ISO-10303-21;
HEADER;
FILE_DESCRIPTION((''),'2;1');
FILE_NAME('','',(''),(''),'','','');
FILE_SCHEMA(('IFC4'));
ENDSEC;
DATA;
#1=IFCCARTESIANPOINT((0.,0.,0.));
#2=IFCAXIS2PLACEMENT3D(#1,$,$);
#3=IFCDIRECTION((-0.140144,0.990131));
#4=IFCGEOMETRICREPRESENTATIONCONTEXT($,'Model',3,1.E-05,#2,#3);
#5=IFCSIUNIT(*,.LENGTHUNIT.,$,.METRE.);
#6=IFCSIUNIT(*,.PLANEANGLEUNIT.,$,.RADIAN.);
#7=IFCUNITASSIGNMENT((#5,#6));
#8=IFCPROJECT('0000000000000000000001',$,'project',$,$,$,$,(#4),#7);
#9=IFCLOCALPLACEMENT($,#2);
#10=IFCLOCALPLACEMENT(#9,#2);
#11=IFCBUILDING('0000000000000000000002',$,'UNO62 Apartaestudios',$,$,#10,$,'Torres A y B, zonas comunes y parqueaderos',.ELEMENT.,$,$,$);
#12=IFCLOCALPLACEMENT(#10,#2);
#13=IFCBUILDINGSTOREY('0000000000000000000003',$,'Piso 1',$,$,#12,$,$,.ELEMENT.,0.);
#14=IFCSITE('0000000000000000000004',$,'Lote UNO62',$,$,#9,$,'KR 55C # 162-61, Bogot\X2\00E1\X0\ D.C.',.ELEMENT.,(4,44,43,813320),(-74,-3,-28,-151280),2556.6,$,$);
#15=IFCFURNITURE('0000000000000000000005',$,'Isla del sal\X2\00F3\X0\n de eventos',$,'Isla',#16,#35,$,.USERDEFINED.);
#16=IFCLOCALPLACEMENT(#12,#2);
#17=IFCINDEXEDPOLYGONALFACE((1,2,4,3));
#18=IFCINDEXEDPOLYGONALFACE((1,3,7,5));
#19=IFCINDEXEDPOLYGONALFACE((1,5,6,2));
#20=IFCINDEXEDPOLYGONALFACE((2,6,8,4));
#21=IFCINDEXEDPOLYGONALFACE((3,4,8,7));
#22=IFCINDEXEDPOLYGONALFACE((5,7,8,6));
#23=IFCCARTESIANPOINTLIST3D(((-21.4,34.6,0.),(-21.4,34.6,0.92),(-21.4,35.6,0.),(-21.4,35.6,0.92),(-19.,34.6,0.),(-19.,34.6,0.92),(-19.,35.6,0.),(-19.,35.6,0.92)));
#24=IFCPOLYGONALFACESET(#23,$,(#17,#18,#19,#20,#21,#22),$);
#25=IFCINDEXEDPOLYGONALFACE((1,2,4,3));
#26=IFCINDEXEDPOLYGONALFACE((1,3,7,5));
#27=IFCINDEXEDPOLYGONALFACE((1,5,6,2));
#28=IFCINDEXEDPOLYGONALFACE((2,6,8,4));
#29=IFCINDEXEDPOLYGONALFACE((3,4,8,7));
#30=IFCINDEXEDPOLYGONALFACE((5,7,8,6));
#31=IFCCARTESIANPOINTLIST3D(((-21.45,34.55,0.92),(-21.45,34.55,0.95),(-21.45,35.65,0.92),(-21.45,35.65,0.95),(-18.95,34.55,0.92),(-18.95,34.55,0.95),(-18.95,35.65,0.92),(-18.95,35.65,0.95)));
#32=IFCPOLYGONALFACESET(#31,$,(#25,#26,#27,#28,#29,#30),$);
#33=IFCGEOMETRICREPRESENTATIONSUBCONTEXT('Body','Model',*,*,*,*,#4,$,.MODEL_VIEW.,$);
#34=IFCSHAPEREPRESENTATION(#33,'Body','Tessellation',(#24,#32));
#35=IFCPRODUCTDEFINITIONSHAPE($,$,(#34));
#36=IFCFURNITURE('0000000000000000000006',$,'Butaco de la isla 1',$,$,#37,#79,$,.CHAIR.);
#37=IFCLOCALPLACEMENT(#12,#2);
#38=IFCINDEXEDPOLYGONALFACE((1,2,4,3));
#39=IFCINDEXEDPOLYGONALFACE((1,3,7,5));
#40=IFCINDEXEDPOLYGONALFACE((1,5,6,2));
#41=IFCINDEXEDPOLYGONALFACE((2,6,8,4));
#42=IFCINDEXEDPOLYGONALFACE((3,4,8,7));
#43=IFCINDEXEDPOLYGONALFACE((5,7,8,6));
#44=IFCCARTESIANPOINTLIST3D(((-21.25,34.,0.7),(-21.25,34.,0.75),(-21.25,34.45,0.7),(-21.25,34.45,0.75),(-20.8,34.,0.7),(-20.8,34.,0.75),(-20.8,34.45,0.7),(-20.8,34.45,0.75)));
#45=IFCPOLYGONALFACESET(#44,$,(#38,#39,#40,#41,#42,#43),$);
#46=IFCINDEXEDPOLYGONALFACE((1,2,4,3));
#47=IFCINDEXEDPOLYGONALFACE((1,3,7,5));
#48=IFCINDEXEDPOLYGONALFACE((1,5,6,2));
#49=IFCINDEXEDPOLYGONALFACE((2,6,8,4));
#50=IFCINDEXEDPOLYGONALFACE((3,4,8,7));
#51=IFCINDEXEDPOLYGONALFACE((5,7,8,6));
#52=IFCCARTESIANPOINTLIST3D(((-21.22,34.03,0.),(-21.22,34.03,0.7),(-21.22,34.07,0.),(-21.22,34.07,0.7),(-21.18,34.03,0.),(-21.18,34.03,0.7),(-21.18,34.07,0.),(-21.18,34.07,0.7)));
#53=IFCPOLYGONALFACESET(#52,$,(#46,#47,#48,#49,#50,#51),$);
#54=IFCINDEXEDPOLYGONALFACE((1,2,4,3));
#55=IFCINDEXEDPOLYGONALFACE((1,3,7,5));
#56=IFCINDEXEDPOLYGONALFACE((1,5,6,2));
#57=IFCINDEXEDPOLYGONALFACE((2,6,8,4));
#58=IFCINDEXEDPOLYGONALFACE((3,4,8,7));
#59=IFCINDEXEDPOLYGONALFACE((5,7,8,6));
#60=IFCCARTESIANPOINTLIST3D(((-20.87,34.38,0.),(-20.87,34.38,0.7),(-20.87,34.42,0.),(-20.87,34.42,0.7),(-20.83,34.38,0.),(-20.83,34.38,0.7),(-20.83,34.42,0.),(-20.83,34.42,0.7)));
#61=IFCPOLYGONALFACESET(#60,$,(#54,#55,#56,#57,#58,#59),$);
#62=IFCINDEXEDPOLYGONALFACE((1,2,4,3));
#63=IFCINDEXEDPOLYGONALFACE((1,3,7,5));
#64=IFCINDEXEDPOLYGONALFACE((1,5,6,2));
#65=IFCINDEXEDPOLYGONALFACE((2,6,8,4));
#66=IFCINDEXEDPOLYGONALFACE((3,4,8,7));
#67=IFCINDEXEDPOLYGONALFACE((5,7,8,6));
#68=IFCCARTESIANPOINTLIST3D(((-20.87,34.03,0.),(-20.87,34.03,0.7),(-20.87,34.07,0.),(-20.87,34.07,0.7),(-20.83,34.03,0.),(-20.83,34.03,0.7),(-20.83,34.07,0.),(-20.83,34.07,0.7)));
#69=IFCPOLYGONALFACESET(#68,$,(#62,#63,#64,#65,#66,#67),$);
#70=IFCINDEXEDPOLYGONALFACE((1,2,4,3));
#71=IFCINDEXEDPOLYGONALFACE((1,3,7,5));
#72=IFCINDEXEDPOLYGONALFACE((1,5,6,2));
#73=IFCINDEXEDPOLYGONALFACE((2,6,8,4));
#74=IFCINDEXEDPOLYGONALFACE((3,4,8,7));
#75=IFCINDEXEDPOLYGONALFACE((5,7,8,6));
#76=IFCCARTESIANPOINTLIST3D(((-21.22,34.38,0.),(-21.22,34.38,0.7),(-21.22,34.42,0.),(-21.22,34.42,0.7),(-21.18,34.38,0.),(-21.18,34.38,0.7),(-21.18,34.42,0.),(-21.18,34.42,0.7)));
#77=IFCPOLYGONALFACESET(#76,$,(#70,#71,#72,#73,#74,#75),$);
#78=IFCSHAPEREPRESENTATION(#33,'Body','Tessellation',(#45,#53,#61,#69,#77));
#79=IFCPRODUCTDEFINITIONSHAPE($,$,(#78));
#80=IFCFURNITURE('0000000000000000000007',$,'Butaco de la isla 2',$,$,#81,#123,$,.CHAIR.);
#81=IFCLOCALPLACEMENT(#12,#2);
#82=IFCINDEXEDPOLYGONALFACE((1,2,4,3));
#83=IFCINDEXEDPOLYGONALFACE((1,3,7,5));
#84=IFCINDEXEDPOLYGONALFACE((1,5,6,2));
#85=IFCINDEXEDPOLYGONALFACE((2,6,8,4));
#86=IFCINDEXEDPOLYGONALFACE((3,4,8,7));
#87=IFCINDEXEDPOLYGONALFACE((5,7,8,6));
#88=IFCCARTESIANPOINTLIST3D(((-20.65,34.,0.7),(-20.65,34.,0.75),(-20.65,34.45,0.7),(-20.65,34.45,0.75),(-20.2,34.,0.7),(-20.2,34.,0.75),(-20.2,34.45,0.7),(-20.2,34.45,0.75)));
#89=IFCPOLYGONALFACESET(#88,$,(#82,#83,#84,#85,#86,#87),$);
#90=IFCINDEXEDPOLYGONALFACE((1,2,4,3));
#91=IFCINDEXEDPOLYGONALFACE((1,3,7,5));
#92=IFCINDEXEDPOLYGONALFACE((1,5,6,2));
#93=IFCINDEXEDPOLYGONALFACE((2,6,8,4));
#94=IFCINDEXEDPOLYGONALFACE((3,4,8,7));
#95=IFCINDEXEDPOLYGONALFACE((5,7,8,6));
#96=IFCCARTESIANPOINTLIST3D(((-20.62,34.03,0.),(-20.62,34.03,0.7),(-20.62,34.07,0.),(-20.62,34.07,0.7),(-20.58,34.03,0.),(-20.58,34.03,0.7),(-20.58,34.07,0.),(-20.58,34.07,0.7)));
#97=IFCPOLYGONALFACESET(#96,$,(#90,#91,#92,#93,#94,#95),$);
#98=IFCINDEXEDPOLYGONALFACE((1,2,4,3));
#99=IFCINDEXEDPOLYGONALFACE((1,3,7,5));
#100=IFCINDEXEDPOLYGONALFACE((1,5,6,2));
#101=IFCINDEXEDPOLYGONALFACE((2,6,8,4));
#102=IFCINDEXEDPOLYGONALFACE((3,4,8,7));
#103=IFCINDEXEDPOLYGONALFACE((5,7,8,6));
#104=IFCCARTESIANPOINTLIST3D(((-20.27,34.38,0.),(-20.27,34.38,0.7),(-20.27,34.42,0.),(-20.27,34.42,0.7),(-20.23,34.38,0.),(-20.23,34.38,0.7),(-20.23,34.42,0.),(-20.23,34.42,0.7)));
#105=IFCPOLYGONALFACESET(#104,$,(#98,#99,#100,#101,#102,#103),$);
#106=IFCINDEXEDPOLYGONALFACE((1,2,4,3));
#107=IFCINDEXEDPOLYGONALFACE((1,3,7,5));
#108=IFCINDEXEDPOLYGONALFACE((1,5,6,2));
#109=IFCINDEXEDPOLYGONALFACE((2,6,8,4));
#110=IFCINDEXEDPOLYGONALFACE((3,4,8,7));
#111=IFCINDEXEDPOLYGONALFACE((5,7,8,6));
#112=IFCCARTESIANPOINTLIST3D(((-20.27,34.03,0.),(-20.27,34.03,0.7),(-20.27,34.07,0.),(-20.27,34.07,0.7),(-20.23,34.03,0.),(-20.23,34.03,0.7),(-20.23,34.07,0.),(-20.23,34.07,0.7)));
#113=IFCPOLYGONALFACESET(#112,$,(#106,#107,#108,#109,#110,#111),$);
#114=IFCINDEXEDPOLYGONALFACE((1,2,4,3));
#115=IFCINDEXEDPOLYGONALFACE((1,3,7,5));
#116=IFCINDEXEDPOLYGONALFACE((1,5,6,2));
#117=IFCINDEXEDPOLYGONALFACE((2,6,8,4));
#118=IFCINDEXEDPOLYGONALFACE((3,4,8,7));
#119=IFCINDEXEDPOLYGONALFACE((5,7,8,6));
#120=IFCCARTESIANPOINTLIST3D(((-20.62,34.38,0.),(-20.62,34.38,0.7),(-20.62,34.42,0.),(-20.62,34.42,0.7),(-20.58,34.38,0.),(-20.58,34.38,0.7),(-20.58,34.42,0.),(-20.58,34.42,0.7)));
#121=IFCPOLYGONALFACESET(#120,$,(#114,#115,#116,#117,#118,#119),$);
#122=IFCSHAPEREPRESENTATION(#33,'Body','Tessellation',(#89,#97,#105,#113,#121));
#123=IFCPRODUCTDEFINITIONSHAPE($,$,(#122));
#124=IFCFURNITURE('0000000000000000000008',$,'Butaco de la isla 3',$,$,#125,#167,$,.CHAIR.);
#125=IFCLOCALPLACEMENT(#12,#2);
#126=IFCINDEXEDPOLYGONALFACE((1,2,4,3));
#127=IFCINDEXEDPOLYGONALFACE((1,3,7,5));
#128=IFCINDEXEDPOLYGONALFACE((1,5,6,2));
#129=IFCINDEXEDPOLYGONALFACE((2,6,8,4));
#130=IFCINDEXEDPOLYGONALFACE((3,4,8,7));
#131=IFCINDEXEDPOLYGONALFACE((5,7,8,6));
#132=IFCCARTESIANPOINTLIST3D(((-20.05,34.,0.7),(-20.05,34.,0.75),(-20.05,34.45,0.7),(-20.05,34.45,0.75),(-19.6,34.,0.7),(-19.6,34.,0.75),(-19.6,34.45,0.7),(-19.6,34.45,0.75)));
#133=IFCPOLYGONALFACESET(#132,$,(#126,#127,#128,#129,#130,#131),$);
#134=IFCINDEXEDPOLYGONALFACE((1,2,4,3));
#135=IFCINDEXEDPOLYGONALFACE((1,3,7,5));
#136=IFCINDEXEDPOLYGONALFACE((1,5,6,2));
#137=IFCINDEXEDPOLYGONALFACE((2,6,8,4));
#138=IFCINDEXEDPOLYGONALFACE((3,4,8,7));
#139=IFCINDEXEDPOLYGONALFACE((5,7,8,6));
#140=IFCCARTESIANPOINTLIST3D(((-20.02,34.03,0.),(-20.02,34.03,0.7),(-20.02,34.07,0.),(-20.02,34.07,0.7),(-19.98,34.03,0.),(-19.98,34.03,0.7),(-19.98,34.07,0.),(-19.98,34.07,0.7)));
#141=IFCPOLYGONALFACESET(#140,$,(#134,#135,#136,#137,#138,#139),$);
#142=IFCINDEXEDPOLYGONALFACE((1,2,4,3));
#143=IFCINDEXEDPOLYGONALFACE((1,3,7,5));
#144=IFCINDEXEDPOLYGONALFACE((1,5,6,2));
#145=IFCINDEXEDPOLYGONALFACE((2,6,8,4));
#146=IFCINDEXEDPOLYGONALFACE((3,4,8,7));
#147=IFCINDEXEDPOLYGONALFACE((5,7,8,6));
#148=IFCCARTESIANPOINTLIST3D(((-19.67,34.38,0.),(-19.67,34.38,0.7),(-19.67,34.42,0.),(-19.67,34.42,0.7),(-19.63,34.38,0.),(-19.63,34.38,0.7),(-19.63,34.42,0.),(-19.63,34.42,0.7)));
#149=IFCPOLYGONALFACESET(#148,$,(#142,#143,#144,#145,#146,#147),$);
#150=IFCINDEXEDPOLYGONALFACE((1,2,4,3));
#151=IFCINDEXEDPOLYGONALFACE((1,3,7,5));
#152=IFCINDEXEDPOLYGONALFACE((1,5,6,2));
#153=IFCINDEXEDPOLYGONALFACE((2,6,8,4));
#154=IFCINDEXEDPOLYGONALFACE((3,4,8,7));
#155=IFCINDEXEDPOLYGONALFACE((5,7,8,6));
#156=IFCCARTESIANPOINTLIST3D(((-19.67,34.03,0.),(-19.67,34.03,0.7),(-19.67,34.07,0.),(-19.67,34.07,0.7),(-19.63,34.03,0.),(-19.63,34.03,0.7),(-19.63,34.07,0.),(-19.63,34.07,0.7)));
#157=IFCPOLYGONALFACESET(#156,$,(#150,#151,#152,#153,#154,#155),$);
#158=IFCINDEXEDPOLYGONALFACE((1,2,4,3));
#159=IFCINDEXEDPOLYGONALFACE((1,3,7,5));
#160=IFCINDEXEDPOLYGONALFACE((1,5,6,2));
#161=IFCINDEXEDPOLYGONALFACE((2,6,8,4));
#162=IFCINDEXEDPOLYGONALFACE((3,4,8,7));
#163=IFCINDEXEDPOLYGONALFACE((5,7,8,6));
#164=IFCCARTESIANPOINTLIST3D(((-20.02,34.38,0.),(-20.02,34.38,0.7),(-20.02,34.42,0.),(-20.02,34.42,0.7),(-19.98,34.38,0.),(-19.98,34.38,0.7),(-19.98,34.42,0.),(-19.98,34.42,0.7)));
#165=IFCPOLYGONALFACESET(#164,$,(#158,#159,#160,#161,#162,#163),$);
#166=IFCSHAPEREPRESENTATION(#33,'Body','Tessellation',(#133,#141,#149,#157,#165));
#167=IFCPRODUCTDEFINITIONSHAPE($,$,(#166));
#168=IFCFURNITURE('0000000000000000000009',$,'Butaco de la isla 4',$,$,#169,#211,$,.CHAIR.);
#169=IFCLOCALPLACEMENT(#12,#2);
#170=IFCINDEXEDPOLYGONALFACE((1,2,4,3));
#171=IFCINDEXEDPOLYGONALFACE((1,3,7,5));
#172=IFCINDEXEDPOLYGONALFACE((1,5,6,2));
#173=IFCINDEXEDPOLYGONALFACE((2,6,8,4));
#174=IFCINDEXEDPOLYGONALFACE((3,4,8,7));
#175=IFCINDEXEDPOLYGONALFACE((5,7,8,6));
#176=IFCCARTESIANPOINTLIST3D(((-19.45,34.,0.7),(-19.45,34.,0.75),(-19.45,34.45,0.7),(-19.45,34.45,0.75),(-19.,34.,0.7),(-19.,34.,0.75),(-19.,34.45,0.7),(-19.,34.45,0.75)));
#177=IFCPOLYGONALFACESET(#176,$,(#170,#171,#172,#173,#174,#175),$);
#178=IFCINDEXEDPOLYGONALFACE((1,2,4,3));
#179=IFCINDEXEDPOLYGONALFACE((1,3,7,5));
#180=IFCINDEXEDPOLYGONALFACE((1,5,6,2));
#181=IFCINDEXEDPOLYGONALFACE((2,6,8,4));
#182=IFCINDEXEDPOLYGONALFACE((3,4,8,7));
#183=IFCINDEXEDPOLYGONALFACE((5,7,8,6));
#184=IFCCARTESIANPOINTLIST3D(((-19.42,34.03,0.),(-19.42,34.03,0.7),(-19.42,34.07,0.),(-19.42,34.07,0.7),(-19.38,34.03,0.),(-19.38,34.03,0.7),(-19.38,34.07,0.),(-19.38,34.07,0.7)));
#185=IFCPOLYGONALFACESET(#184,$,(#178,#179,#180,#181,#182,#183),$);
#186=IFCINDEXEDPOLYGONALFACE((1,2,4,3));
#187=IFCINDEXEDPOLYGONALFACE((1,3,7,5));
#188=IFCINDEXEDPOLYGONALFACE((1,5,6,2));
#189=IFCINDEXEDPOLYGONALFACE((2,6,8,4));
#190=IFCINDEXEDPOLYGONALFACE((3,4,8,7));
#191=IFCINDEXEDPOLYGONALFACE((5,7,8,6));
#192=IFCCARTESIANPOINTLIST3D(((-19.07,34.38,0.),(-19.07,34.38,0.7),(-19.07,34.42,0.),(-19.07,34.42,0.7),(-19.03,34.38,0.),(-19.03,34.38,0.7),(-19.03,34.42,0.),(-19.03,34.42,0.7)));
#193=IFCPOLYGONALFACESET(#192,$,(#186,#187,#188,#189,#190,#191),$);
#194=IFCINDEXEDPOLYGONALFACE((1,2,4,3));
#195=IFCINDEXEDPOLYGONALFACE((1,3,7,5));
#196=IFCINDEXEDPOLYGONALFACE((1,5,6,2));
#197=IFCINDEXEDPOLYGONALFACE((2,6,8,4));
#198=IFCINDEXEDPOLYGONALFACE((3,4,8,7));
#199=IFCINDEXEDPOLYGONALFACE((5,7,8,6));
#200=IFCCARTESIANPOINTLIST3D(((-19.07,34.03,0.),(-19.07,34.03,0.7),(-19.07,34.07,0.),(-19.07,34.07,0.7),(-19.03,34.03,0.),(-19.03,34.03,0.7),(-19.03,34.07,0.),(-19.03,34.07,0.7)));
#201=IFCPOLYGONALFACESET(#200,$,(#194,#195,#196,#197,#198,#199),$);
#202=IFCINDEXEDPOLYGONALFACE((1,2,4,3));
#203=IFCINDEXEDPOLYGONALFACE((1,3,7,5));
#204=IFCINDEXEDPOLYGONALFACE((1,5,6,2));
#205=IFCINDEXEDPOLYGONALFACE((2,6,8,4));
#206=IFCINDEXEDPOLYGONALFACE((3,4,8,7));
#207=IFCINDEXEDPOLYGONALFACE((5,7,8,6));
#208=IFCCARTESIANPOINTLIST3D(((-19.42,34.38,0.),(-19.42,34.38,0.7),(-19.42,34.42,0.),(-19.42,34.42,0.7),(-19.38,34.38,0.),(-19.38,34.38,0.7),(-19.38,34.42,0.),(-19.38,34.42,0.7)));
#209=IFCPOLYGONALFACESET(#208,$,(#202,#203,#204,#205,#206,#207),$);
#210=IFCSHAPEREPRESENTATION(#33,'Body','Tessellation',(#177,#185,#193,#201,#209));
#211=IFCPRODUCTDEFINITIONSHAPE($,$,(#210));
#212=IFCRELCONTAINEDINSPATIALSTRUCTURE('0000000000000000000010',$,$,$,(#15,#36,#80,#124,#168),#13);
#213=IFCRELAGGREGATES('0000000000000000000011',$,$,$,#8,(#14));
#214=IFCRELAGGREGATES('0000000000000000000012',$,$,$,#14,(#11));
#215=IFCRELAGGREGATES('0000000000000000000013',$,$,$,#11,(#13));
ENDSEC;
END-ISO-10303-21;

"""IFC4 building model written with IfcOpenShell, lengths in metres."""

from ifc_helpers import new_model, si_unit, direction, frame, frame_2d, origin, place, context, subcontext, project, spatial, rectangle, extrude, element, save


model = new_model("IFC4")

# Units and contexts
model_context = context("Model", 3, precision=1e-05, world=origin(), true_north=direction((-0.140144, 0.990131)))
body_context = subcontext(model_context, "Body", "Model", "MODEL_VIEW")
ifc_project = project(units=[si_unit("LENGTHUNIT", "METRE"), si_unit("PLANEANGLEUNIT", "RADIAN")], contexts=[model_context])

# Site, building, storey
site_placement = place(None, origin())
site = spatial("IfcSite", under=ifc_project, at=site_placement, Name="Lote UNO62", LongName="KR 55C # 162-61, Bogotá D.C.", CompositionType="ELEMENT", RefLatitude=(4, 44, 43, 813320), RefLongitude=(-74, -3, -28, -151280), RefElevation=2556.6)
building_placement = place(site_placement, origin())
building = spatial("IfcBuilding", under=site, at=building_placement, Name="UNO62 Apartaestudios", LongName="Torres A y B, zonas comunes y parqueaderos", CompositionType="ELEMENT")
storey_placement = place(building_placement, origin())
storey = spatial("IfcBuildingStorey", under=building, at=storey_placement, Name="Piso 1", CompositionType="ELEMENT", Elevation=0.0)

# Furniture
furniture_1_placement = place(storey_placement, origin())
element("IfcFurniture", 1, at=furniture_1_placement, inside=storey, Name="Isla del salón de eventos", ObjectType="Isla", PredefinedType="USERDEFINED", context=body_context, shape_type="SweptSolid", body=[
    extrude(rectangle(XDim=2.4, YDim=1.0, at=frame_2d((-20.2, 35.1))), origin(), (0.0, 0.0, 1.0), 0.92),
    extrude(rectangle(XDim=2.5, YDim=1.1, at=frame_2d((-20.2, 35.1))), frame((0.0, 0.0, 0.92)), (0.0, 0.0, 1.0), 0.03),
])
furniture_2_placement = place(storey_placement, origin())
element("IfcFurniture", 2, at=furniture_2_placement, inside=storey, Name="Butaco de la isla 1", PredefinedType="CHAIR", context=body_context, shape_type="SweptSolid", body=[
    extrude(rectangle(XDim=0.45, YDim=0.45, at=frame_2d((-21.025, 34.225))), frame((0.0, 0.0, 0.7)), (0.0, 0.0, 1.0), 0.05),
    extrude(rectangle(XDim=0.04, YDim=0.04, at=frame_2d((-21.2, 34.05))), origin(), (0.0, 0.0, 1.0), 0.7),
    extrude(rectangle(XDim=0.04, YDim=0.04, at=frame_2d((-20.85, 34.4))), origin(), (0.0, 0.0, 1.0), 0.7),
    extrude(rectangle(XDim=0.04, YDim=0.04, at=frame_2d((-20.85, 34.05))), origin(), (0.0, 0.0, 1.0), 0.7),
    extrude(rectangle(XDim=0.04, YDim=0.04, at=frame_2d((-21.2, 34.4))), origin(), (0.0, 0.0, 1.0), 0.7),
])
furniture_3_placement = place(storey_placement, origin())
element("IfcFurniture", 3, at=furniture_3_placement, inside=storey, Name="Butaco de la isla 2", PredefinedType="CHAIR", context=body_context, shape_type="SweptSolid", body=[
    extrude(rectangle(XDim=0.45, YDim=0.45, at=frame_2d((-20.425, 34.225))), frame((0.0, 0.0, 0.7)), (0.0, 0.0, 1.0), 0.05),
    extrude(rectangle(XDim=0.04, YDim=0.04, at=frame_2d((-20.6, 34.05))), origin(), (0.0, 0.0, 1.0), 0.7),
    extrude(rectangle(XDim=0.04, YDim=0.04, at=frame_2d((-20.25, 34.4))), origin(), (0.0, 0.0, 1.0), 0.7),
    extrude(rectangle(XDim=0.04, YDim=0.04, at=frame_2d((-20.25, 34.05))), origin(), (0.0, 0.0, 1.0), 0.7),
    extrude(rectangle(XDim=0.04, YDim=0.04, at=frame_2d((-20.6, 34.4))), origin(), (0.0, 0.0, 1.0), 0.7),
])
furniture_4_placement = place(storey_placement, origin())
element("IfcFurniture", 4, at=furniture_4_placement, inside=storey, Name="Butaco de la isla 3", PredefinedType="CHAIR", context=body_context, shape_type="SweptSolid", body=[
    extrude(rectangle(XDim=0.45, YDim=0.45, at=frame_2d((-19.825, 34.225))), frame((0.0, 0.0, 0.7)), (0.0, 0.0, 1.0), 0.05),
    extrude(rectangle(XDim=0.04, YDim=0.04, at=frame_2d((-20.0, 34.05))), origin(), (0.0, 0.0, 1.0), 0.7),
    extrude(rectangle(XDim=0.04, YDim=0.04, at=frame_2d((-19.65, 34.4))), origin(), (0.0, 0.0, 1.0), 0.7),
    extrude(rectangle(XDim=0.04, YDim=0.04, at=frame_2d((-19.65, 34.05))), origin(), (0.0, 0.0, 1.0), 0.7),
    extrude(rectangle(XDim=0.04, YDim=0.04, at=frame_2d((-20.0, 34.4))), origin(), (0.0, 0.0, 1.0), 0.7),
])
furniture_5_placement = place(storey_placement, origin())
element("IfcFurniture", 5, at=furniture_5_placement, inside=storey, Name="Butaco de la isla 4", PredefinedType="CHAIR", context=body_context, shape_type="SweptSolid", body=[
    extrude(rectangle(XDim=0.45, YDim=0.45, at=frame_2d((-19.225, 34.225))), frame((0.0, 0.0, 0.7)), (0.0, 0.0, 1.0), 0.05),
    extrude(rectangle(XDim=0.04, YDim=0.04, at=frame_2d((-19.4, 34.05))), origin(), (0.0, 0.0, 1.0), 0.7),
    extrude(rectangle(XDim=0.04, YDim=0.04, at=frame_2d((-19.05, 34.4))), origin(), (0.0, 0.0, 1.0), 0.7),
    extrude(rectangle(XDim=0.04, YDim=0.04, at=frame_2d((-19.05, 34.05))), origin(), (0.0, 0.0, 1.0), 0.7),
    extrude(rectangle(XDim=0.04, YDim=0.04, at=frame_2d((-19.4, 34.4))), origin(), (0.0, 0.0, 1.0), 0.7),
])

save(model, "model.ifc")
